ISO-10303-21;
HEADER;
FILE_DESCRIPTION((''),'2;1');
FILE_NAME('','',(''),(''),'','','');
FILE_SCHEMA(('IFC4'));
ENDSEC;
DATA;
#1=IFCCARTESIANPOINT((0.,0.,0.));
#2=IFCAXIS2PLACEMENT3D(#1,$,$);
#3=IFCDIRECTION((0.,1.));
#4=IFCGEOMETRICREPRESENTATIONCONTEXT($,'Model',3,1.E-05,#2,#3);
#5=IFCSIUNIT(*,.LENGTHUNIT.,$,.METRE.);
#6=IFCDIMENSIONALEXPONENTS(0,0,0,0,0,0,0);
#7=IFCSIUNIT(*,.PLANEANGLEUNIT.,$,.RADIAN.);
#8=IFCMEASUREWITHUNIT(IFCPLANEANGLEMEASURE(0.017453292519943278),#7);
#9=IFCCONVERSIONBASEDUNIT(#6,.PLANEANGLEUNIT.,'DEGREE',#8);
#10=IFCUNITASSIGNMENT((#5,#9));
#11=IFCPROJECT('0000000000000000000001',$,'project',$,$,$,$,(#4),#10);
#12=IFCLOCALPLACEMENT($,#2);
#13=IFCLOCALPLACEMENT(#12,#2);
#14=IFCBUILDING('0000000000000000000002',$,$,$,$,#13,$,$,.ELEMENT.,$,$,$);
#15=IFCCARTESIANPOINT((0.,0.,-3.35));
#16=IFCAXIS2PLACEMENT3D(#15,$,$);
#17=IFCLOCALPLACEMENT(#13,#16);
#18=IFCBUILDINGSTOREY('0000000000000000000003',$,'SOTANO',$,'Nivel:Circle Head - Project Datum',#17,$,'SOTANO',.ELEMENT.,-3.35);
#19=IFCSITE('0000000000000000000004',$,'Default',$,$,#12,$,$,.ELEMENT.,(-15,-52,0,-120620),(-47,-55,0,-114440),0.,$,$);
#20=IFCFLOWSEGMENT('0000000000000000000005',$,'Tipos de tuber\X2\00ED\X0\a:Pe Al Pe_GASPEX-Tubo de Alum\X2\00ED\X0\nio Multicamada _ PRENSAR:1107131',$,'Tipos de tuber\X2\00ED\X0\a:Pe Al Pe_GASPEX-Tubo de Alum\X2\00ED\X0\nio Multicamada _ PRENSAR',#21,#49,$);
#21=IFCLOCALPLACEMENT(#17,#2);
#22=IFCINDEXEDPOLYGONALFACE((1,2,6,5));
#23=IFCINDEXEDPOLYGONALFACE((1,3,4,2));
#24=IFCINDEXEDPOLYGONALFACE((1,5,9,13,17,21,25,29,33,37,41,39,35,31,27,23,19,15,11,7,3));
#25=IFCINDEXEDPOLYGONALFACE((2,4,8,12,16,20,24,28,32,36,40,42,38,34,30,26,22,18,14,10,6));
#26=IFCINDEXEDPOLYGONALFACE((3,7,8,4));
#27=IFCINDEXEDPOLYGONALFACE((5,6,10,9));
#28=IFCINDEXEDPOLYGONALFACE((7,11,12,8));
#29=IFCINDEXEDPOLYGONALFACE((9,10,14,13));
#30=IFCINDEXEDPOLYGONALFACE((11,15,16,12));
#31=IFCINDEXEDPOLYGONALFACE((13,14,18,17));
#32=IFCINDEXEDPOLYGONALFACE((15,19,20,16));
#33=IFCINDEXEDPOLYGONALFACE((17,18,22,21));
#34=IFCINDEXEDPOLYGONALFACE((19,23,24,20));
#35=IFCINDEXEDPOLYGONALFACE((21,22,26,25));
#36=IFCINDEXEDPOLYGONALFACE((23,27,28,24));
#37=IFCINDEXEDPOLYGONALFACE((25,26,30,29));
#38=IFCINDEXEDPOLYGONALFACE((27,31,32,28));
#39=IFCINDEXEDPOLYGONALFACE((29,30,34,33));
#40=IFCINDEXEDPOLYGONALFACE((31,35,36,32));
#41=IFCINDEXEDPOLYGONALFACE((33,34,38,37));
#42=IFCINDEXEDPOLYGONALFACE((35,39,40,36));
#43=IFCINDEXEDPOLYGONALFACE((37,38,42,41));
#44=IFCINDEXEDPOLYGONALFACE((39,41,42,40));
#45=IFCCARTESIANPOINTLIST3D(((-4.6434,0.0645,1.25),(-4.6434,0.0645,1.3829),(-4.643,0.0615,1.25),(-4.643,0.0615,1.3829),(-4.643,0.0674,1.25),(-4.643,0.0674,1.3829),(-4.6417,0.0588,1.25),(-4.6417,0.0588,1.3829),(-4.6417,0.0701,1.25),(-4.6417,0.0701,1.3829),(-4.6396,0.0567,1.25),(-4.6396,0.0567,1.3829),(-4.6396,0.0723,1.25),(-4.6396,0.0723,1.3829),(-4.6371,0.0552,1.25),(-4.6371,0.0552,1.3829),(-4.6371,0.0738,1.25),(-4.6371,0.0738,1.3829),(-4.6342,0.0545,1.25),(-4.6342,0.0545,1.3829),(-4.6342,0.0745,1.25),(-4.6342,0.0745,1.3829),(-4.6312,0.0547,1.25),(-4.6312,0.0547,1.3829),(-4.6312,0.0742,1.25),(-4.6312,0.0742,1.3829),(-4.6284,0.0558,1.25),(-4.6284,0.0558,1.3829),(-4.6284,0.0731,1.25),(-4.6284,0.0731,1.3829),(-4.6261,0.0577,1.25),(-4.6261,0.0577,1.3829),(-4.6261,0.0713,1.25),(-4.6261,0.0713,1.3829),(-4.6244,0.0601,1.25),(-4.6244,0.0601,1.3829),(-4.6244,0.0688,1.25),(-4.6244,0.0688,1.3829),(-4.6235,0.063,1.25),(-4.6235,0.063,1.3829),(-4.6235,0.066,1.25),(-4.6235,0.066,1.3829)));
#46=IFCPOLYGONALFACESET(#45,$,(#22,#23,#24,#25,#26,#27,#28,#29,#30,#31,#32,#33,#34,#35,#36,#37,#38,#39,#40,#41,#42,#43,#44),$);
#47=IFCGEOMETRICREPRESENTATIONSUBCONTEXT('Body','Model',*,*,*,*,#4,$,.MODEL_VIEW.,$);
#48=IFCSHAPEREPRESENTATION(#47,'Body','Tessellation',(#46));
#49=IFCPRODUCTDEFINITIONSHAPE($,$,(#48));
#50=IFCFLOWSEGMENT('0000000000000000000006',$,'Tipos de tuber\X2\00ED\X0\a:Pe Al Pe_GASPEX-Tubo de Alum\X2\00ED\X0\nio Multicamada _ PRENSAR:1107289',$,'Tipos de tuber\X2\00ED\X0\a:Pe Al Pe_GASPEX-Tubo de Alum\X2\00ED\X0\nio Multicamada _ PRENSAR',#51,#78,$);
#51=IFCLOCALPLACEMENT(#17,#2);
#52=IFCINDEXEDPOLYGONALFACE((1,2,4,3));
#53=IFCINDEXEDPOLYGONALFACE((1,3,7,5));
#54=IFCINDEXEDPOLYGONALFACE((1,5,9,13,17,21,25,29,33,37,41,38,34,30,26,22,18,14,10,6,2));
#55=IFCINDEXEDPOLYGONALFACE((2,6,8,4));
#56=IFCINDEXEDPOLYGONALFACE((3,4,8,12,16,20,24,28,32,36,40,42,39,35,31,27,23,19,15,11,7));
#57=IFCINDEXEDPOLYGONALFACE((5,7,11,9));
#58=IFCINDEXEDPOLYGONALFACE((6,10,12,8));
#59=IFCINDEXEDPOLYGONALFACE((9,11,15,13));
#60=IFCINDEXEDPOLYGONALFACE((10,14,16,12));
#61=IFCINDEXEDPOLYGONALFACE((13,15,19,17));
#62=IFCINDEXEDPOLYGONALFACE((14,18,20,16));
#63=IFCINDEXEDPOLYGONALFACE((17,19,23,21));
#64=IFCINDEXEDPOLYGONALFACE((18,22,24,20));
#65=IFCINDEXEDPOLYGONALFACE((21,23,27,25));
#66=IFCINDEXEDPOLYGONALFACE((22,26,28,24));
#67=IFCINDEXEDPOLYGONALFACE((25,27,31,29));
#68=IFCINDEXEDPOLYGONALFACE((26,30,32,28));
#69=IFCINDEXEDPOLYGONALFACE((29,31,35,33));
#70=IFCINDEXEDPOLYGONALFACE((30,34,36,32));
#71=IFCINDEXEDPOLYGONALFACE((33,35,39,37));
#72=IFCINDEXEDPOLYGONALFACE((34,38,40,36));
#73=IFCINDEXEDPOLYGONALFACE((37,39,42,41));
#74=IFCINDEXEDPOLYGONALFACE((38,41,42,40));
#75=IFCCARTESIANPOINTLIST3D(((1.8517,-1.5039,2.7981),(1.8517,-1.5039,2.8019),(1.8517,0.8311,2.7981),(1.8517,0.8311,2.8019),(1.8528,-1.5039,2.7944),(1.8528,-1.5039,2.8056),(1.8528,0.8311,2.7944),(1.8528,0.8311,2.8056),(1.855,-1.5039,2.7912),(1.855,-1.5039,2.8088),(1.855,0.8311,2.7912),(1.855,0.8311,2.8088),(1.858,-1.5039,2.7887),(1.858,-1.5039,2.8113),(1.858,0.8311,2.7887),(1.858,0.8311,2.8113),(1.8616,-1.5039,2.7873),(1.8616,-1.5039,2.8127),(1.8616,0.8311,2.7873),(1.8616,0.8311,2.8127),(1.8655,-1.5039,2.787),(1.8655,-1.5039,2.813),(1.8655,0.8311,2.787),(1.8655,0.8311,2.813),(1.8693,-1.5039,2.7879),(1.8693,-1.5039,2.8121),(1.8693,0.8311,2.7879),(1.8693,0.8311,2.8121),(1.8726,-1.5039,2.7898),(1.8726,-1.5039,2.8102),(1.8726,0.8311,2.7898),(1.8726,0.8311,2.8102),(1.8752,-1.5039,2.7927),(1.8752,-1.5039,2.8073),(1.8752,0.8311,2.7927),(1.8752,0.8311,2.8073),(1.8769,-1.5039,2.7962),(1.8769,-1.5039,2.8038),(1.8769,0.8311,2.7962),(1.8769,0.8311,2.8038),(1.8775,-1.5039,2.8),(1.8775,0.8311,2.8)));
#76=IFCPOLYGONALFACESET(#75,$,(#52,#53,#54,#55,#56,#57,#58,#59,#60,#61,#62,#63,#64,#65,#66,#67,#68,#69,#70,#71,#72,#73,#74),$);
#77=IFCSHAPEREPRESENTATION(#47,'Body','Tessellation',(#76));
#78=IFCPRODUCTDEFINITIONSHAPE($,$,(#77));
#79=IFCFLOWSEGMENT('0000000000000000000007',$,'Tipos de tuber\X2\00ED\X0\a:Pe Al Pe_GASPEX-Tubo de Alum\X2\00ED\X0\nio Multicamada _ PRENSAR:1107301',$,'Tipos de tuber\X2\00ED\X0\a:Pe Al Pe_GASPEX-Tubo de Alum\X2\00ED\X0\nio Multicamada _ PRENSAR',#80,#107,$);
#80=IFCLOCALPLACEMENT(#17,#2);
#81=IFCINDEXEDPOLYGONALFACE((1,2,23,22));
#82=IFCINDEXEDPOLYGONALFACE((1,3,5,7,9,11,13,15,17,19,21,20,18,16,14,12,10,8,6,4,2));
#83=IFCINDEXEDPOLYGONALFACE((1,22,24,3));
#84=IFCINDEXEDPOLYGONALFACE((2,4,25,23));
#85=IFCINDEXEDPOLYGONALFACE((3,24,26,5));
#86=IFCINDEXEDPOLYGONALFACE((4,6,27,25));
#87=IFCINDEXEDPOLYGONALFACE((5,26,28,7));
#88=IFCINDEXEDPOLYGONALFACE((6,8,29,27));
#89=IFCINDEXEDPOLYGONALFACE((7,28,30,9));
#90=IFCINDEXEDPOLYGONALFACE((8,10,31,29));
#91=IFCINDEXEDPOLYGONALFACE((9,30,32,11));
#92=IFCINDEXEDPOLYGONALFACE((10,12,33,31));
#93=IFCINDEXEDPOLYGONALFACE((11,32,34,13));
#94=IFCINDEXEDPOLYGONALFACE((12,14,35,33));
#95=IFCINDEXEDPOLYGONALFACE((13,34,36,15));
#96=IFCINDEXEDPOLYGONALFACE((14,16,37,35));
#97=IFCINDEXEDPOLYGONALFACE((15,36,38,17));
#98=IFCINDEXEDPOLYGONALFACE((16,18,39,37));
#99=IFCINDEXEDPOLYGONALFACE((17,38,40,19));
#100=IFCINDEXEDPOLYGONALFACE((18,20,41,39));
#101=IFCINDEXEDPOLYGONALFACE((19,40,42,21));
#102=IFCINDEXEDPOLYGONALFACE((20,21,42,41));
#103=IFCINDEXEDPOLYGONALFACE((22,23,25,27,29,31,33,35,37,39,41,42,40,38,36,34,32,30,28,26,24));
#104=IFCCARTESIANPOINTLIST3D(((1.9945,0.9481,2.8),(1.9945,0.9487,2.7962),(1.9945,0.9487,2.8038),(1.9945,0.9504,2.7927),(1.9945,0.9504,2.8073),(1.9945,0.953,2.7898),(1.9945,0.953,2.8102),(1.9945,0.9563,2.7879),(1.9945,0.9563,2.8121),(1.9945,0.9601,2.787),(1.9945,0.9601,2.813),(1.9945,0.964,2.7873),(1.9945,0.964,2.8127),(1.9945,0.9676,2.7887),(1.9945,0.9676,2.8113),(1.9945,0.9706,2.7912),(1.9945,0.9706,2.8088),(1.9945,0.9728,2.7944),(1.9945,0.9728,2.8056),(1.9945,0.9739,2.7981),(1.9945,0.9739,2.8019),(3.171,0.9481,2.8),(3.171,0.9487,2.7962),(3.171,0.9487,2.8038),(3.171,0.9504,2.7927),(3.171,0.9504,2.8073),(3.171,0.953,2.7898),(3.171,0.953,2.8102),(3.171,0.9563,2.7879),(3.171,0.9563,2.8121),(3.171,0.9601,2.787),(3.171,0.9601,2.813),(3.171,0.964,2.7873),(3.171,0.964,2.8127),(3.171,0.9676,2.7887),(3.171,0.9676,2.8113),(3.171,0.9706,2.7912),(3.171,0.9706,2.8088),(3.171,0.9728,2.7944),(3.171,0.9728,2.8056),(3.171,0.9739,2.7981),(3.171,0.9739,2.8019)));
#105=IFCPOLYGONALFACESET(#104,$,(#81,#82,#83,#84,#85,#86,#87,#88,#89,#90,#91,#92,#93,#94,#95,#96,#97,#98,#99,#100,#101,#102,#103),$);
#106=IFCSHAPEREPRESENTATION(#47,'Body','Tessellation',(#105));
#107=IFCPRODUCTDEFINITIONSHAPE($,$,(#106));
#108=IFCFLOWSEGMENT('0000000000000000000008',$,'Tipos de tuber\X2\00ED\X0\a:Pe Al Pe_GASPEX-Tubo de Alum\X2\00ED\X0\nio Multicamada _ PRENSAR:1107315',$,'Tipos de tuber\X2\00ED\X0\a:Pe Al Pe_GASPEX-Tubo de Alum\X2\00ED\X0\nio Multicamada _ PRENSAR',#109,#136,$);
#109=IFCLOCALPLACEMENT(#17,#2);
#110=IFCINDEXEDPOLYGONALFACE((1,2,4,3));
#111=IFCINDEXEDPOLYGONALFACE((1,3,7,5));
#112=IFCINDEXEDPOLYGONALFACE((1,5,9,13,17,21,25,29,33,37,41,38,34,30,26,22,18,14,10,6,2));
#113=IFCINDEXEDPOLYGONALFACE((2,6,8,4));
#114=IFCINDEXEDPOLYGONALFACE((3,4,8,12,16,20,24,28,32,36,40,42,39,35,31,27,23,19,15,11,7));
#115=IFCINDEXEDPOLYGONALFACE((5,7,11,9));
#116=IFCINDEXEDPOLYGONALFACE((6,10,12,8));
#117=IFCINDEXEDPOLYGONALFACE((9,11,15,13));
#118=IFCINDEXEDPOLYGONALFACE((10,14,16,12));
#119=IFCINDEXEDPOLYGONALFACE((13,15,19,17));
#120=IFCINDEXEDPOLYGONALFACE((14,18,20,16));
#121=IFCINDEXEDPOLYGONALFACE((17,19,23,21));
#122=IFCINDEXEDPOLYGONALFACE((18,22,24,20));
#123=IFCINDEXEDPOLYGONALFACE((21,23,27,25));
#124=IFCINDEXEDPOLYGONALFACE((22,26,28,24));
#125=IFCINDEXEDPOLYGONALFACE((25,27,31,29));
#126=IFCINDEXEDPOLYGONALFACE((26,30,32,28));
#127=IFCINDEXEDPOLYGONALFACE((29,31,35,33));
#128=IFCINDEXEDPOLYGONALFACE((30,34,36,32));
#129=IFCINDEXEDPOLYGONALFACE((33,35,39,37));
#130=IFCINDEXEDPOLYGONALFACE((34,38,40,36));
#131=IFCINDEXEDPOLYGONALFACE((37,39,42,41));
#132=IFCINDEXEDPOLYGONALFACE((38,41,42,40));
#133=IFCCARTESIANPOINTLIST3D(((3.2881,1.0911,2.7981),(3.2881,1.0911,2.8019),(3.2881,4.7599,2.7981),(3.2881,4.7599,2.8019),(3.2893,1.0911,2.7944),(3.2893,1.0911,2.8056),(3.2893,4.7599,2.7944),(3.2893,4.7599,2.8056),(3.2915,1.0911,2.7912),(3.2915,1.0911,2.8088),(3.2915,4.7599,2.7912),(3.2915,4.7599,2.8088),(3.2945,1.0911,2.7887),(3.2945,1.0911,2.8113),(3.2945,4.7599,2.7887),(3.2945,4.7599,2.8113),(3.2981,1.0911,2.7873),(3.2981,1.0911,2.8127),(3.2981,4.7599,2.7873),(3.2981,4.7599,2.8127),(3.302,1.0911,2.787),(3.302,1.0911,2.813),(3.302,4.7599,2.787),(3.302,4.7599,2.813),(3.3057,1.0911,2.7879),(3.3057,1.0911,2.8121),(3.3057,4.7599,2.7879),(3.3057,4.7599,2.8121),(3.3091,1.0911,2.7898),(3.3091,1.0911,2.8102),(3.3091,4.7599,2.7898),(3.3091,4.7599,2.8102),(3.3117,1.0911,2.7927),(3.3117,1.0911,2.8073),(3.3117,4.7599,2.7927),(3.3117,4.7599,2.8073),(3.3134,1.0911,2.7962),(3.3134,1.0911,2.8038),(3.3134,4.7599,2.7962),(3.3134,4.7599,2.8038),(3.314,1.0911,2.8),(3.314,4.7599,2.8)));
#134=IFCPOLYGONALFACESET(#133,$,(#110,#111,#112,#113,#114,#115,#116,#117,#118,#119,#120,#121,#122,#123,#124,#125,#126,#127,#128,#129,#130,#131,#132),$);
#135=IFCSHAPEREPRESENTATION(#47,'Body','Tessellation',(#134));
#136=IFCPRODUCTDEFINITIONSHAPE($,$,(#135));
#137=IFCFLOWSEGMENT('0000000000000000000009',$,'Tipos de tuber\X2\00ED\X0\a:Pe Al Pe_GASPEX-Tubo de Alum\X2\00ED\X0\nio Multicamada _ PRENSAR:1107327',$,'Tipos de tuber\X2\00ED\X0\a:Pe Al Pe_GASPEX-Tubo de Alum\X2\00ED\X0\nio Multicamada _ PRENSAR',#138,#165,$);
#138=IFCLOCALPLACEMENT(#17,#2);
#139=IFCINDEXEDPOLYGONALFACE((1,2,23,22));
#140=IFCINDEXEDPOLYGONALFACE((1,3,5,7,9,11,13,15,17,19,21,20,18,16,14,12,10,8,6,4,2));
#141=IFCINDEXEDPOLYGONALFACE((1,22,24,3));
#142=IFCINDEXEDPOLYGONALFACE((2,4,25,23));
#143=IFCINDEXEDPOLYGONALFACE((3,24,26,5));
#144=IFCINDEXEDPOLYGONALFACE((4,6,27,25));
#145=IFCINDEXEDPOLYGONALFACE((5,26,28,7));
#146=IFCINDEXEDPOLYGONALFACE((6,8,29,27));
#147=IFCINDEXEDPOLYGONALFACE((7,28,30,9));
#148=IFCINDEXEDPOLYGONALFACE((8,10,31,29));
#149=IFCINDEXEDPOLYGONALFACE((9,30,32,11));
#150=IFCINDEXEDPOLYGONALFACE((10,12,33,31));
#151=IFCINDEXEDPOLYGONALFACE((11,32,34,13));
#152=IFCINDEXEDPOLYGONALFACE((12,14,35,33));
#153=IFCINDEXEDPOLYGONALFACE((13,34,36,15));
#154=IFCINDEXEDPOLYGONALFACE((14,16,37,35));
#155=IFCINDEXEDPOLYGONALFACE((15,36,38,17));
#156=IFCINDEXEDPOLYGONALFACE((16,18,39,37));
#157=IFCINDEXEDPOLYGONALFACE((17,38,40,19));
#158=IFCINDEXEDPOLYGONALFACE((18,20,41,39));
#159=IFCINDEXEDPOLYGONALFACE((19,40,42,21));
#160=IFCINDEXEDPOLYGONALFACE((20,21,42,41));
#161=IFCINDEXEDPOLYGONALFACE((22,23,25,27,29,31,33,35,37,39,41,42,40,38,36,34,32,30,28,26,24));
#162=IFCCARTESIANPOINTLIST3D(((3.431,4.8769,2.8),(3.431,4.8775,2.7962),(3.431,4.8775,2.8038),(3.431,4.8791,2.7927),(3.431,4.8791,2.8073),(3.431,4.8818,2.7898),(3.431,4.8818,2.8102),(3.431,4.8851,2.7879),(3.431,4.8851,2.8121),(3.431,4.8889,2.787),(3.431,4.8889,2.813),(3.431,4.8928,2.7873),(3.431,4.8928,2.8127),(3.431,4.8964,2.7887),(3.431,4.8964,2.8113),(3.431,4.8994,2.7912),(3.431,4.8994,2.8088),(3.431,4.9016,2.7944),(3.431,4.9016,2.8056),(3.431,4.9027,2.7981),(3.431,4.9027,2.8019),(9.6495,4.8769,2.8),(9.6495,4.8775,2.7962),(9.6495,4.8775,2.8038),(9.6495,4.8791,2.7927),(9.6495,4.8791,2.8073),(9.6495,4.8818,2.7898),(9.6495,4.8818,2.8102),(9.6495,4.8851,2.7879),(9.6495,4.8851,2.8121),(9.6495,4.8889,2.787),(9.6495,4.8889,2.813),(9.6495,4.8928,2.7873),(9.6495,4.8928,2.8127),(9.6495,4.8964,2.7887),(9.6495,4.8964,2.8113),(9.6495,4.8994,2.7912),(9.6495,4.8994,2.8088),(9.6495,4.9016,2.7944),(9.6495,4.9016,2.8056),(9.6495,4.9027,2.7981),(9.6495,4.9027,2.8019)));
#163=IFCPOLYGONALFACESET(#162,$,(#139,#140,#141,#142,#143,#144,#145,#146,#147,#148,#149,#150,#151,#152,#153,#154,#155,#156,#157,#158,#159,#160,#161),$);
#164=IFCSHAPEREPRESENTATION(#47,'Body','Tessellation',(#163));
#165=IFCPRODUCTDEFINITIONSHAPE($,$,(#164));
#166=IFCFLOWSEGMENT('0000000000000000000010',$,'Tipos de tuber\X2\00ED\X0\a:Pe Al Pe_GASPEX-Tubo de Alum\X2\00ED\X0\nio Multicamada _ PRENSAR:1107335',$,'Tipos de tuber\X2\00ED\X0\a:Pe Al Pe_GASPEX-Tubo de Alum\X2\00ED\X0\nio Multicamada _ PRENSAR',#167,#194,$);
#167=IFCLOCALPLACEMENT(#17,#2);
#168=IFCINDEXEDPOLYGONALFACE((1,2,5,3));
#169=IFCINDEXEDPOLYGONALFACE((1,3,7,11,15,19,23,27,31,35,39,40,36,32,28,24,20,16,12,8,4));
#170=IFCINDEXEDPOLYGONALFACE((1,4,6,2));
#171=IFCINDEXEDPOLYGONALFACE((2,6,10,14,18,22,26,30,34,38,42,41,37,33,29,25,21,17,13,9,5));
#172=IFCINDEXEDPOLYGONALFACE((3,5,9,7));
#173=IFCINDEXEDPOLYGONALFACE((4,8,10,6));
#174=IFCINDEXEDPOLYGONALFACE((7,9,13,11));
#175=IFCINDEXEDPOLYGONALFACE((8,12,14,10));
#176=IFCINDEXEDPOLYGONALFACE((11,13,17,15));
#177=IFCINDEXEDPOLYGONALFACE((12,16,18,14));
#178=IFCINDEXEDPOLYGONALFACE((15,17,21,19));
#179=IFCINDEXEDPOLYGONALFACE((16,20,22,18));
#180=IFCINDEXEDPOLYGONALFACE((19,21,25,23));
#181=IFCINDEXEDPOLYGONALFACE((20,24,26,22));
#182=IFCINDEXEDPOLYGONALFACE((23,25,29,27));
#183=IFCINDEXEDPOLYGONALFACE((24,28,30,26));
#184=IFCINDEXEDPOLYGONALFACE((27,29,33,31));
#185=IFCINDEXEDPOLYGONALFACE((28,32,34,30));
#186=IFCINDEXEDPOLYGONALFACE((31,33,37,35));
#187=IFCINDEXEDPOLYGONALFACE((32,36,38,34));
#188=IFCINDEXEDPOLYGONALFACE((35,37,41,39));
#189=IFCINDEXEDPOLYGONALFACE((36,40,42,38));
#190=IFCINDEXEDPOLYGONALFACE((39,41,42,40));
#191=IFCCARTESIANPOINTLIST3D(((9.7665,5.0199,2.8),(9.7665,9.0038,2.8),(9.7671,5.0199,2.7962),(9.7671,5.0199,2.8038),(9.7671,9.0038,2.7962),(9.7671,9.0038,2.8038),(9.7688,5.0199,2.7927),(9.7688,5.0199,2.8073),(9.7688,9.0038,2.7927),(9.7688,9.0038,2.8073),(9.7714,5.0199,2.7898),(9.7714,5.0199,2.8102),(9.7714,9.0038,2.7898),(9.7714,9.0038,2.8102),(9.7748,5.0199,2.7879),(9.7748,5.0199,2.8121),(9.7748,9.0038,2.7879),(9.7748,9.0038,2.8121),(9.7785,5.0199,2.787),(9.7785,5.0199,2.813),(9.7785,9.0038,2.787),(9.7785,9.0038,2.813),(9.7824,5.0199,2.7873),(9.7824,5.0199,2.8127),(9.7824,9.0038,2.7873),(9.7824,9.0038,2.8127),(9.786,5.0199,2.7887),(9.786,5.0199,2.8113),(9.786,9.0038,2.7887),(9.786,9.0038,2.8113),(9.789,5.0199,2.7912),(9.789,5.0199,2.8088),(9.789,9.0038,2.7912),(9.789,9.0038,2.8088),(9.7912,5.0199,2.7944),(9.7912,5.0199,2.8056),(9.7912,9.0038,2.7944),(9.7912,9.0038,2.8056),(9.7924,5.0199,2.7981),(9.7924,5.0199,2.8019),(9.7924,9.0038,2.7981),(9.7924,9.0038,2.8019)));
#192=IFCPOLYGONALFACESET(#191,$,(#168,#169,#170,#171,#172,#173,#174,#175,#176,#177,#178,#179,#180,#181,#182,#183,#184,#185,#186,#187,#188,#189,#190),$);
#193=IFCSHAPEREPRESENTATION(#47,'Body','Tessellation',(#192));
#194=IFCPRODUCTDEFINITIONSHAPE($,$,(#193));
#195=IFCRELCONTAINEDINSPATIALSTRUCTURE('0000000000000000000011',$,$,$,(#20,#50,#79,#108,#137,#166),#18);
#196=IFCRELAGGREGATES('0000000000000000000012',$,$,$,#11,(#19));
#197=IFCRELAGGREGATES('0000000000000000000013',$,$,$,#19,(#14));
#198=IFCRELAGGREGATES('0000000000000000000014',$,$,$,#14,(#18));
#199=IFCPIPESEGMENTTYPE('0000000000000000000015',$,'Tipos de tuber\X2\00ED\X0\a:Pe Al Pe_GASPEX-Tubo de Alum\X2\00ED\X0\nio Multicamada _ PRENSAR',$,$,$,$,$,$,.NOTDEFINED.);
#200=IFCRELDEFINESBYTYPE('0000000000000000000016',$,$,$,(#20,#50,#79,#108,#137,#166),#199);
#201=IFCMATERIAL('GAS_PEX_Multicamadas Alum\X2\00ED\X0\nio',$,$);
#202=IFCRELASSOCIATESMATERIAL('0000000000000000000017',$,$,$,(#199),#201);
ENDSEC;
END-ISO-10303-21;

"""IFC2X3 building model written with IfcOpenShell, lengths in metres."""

from ifc_helpers import new_model, entity, si_unit, converted_unit, direction, frame, frame_2d, origin, origin_2d_with_axis, place, context, subcontext, project, spatial, circle, extrude, material, type_object, element, save


model = new_model("IFC2X3")

# Units and contexts
model_context = context("Model", 3, precision=1e-05, world=origin(), true_north=direction((0.0, 1.0)))
body_context = subcontext(model_context, "Body", "Model", "MODEL_VIEW")
ifc_project = project(units=[si_unit("LENGTHUNIT", "METRE"), converted_unit("PLANEANGLEUNIT", "DEGREE", entity("IfcPlaneAngleMeasure", 0.017453292519943278), si_unit("PLANEANGLEUNIT", "RADIAN"), dimensions=[0, 0, 0, 0, 0, 0, 0])], contexts=[model_context])

# Site, building, storey
site_placement = place(None, origin())
site = spatial("IfcSite", under=ifc_project, at=site_placement, Name="Default", CompositionType="ELEMENT", RefLatitude=(-15, -52, 0, -120620), RefLongitude=(-47, -55, 0, -114440), RefElevation=0.0)
building_placement = place(site_placement, origin())
building = spatial("IfcBuilding", under=site, at=building_placement, CompositionType="ELEMENT")
storey_placement = place(building_placement, frame((0.0, 0.0, -3.35)))
storey = spatial("IfcBuildingStorey", under=building, at=storey_placement, Name="SOTANO", ObjectType="Nivel:Circle Head - Project Datum", LongName="SOTANO", CompositionType="ELEMENT", Elevation=-3.35)

# Flow segments
ifc_material = material(Name="GAS_PEX_Multicamadas Alumínio")
pipe_segment_type_1 = type_object("IfcPipeSegmentType", Name="Tipos de tubería:Pe Al Pe_GASPEX-Tubo de Alumínio Multicamada _ PRENSAR", PredefinedType="NOTDEFINED", material=ifc_material)
flow_segment_1_placement = place(storey_placement, origin())
element("IfcFlowSegment", 1, at=flow_segment_1_placement, inside=storey, type_object=pipe_segment_type_1, Name="Tipos de tubería:Pe Al Pe_GASPEX-Tubo de Alumínio Multicamada _ PRENSAR:1107131", ObjectType="Tipos de tubería:Pe Al Pe_GASPEX-Tubo de Alumínio Multicamada _ PRENSAR", context=body_context, shape_type="SweptSolid", body=[
    extrude(circle(Radius=0.01, at=frame_2d((0.0, 0.0), x_axis=(1.0, 0.0))), frame((-4.6334, 0.0645, 1.25), z_axis=(0.0, 0.0, 1.0), x_axis=(-1.0, 0.0, 0.0)), (0.0, 0.0, 1.0), 0.1328),
])
flow_segment_2_placement = place(storey_placement, origin())
element("IfcFlowSegment", 2, at=flow_segment_2_placement, inside=storey, type_object=pipe_segment_type_1, Name="Tipos de tubería:Pe Al Pe_GASPEX-Tubo de Alumínio Multicamada _ PRENSAR:1107289", ObjectType="Tipos de tubería:Pe Al Pe_GASPEX-Tubo de Alumínio Multicamada _ PRENSAR", context=body_context, shape_type="SweptSolid", body=[
    extrude(circle(Radius=0.013, at=origin_2d_with_axis()), frame((1.8645, -1.5039, 2.8), z_axis=(0.0, 1.0, 0.0), x_axis=(1.0, 0.0, 0.0)), (0.0, 0.0, 1.0), 2.335),
])
flow_segment_3_placement = place(storey_placement, origin())
element("IfcFlowSegment", 3, at=flow_segment_3_placement, inside=storey, type_object=pipe_segment_type_1, Name="Tipos de tubería:Pe Al Pe_GASPEX-Tubo de Alumínio Multicamada _ PRENSAR:1107301", ObjectType="Tipos de tubería:Pe Al Pe_GASPEX-Tubo de Alumínio Multicamada _ PRENSAR", context=body_context, shape_type="SweptSolid", body=[
    extrude(circle(Radius=0.013, at=origin_2d_with_axis()), frame((1.9945, 0.9611, 2.8), z_axis=(1.0, 0.0, 0.0), x_axis=(0.0, -1.0, 0.0)), (0.0, 0.0, 1.0), 1.1765),
])
flow_segment_4_placement = place(storey_placement, origin())
element("IfcFlowSegment", 4, at=flow_segment_4_placement, inside=storey, type_object=pipe_segment_type_1, Name="Tipos de tubería:Pe Al Pe_GASPEX-Tubo de Alumínio Multicamada _ PRENSAR:1107315", ObjectType="Tipos de tubería:Pe Al Pe_GASPEX-Tubo de Alumínio Multicamada _ PRENSAR", context=body_context, shape_type="SweptSolid", body=[
    extrude(circle(Radius=0.013, at=origin_2d_with_axis()), frame((3.301, 1.0911, 2.8), z_axis=(0.0, 1.0, 0.0), x_axis=(1.0, 0.0, 0.0)), (0.0, 0.0, 1.0), 3.6688),
])
flow_segment_5_placement = place(storey_placement, origin())
element("IfcFlowSegment", 5, at=flow_segment_5_placement, inside=storey, type_object=pipe_segment_type_1, Name="Tipos de tubería:Pe Al Pe_GASPEX-Tubo de Alumínio Multicamada _ PRENSAR:1107327", ObjectType="Tipos de tubería:Pe Al Pe_GASPEX-Tubo de Alumínio Multicamada _ PRENSAR", context=body_context, shape_type="SweptSolid", body=[
    extrude(circle(Radius=0.013, at=origin_2d_with_axis()), frame((3.431, 4.8899, 2.8), z_axis=(1.0, 0.0, 0.0), x_axis=(0.0, -1.0, 0.0)), (0.0, 0.0, 1.0), 6.2185),
])
flow_segment_6_placement = place(storey_placement, origin())
element("IfcFlowSegment", 6, at=flow_segment_6_placement, inside=storey, type_object=pipe_segment_type_1, Name="Tipos de tubería:Pe Al Pe_GASPEX-Tubo de Alumínio Multicamada _ PRENSAR:1107335", ObjectType="Tipos de tubería:Pe Al Pe_GASPEX-Tubo de Alumínio Multicamada _ PRENSAR", context=body_context, shape_type="SweptSolid", body=[
    extrude(circle(Radius=0.013, at=frame_2d((0.0, 0.0), x_axis=(1.0, 0.0))), frame((9.7795, 5.0199, 2.8), z_axis=(0.0, 1.0, 0.0), x_axis=(-1.0, 0.0, 0.0)), (0.0, 0.0, 1.0), 3.9839),
])

save(model, "model.ifc")
